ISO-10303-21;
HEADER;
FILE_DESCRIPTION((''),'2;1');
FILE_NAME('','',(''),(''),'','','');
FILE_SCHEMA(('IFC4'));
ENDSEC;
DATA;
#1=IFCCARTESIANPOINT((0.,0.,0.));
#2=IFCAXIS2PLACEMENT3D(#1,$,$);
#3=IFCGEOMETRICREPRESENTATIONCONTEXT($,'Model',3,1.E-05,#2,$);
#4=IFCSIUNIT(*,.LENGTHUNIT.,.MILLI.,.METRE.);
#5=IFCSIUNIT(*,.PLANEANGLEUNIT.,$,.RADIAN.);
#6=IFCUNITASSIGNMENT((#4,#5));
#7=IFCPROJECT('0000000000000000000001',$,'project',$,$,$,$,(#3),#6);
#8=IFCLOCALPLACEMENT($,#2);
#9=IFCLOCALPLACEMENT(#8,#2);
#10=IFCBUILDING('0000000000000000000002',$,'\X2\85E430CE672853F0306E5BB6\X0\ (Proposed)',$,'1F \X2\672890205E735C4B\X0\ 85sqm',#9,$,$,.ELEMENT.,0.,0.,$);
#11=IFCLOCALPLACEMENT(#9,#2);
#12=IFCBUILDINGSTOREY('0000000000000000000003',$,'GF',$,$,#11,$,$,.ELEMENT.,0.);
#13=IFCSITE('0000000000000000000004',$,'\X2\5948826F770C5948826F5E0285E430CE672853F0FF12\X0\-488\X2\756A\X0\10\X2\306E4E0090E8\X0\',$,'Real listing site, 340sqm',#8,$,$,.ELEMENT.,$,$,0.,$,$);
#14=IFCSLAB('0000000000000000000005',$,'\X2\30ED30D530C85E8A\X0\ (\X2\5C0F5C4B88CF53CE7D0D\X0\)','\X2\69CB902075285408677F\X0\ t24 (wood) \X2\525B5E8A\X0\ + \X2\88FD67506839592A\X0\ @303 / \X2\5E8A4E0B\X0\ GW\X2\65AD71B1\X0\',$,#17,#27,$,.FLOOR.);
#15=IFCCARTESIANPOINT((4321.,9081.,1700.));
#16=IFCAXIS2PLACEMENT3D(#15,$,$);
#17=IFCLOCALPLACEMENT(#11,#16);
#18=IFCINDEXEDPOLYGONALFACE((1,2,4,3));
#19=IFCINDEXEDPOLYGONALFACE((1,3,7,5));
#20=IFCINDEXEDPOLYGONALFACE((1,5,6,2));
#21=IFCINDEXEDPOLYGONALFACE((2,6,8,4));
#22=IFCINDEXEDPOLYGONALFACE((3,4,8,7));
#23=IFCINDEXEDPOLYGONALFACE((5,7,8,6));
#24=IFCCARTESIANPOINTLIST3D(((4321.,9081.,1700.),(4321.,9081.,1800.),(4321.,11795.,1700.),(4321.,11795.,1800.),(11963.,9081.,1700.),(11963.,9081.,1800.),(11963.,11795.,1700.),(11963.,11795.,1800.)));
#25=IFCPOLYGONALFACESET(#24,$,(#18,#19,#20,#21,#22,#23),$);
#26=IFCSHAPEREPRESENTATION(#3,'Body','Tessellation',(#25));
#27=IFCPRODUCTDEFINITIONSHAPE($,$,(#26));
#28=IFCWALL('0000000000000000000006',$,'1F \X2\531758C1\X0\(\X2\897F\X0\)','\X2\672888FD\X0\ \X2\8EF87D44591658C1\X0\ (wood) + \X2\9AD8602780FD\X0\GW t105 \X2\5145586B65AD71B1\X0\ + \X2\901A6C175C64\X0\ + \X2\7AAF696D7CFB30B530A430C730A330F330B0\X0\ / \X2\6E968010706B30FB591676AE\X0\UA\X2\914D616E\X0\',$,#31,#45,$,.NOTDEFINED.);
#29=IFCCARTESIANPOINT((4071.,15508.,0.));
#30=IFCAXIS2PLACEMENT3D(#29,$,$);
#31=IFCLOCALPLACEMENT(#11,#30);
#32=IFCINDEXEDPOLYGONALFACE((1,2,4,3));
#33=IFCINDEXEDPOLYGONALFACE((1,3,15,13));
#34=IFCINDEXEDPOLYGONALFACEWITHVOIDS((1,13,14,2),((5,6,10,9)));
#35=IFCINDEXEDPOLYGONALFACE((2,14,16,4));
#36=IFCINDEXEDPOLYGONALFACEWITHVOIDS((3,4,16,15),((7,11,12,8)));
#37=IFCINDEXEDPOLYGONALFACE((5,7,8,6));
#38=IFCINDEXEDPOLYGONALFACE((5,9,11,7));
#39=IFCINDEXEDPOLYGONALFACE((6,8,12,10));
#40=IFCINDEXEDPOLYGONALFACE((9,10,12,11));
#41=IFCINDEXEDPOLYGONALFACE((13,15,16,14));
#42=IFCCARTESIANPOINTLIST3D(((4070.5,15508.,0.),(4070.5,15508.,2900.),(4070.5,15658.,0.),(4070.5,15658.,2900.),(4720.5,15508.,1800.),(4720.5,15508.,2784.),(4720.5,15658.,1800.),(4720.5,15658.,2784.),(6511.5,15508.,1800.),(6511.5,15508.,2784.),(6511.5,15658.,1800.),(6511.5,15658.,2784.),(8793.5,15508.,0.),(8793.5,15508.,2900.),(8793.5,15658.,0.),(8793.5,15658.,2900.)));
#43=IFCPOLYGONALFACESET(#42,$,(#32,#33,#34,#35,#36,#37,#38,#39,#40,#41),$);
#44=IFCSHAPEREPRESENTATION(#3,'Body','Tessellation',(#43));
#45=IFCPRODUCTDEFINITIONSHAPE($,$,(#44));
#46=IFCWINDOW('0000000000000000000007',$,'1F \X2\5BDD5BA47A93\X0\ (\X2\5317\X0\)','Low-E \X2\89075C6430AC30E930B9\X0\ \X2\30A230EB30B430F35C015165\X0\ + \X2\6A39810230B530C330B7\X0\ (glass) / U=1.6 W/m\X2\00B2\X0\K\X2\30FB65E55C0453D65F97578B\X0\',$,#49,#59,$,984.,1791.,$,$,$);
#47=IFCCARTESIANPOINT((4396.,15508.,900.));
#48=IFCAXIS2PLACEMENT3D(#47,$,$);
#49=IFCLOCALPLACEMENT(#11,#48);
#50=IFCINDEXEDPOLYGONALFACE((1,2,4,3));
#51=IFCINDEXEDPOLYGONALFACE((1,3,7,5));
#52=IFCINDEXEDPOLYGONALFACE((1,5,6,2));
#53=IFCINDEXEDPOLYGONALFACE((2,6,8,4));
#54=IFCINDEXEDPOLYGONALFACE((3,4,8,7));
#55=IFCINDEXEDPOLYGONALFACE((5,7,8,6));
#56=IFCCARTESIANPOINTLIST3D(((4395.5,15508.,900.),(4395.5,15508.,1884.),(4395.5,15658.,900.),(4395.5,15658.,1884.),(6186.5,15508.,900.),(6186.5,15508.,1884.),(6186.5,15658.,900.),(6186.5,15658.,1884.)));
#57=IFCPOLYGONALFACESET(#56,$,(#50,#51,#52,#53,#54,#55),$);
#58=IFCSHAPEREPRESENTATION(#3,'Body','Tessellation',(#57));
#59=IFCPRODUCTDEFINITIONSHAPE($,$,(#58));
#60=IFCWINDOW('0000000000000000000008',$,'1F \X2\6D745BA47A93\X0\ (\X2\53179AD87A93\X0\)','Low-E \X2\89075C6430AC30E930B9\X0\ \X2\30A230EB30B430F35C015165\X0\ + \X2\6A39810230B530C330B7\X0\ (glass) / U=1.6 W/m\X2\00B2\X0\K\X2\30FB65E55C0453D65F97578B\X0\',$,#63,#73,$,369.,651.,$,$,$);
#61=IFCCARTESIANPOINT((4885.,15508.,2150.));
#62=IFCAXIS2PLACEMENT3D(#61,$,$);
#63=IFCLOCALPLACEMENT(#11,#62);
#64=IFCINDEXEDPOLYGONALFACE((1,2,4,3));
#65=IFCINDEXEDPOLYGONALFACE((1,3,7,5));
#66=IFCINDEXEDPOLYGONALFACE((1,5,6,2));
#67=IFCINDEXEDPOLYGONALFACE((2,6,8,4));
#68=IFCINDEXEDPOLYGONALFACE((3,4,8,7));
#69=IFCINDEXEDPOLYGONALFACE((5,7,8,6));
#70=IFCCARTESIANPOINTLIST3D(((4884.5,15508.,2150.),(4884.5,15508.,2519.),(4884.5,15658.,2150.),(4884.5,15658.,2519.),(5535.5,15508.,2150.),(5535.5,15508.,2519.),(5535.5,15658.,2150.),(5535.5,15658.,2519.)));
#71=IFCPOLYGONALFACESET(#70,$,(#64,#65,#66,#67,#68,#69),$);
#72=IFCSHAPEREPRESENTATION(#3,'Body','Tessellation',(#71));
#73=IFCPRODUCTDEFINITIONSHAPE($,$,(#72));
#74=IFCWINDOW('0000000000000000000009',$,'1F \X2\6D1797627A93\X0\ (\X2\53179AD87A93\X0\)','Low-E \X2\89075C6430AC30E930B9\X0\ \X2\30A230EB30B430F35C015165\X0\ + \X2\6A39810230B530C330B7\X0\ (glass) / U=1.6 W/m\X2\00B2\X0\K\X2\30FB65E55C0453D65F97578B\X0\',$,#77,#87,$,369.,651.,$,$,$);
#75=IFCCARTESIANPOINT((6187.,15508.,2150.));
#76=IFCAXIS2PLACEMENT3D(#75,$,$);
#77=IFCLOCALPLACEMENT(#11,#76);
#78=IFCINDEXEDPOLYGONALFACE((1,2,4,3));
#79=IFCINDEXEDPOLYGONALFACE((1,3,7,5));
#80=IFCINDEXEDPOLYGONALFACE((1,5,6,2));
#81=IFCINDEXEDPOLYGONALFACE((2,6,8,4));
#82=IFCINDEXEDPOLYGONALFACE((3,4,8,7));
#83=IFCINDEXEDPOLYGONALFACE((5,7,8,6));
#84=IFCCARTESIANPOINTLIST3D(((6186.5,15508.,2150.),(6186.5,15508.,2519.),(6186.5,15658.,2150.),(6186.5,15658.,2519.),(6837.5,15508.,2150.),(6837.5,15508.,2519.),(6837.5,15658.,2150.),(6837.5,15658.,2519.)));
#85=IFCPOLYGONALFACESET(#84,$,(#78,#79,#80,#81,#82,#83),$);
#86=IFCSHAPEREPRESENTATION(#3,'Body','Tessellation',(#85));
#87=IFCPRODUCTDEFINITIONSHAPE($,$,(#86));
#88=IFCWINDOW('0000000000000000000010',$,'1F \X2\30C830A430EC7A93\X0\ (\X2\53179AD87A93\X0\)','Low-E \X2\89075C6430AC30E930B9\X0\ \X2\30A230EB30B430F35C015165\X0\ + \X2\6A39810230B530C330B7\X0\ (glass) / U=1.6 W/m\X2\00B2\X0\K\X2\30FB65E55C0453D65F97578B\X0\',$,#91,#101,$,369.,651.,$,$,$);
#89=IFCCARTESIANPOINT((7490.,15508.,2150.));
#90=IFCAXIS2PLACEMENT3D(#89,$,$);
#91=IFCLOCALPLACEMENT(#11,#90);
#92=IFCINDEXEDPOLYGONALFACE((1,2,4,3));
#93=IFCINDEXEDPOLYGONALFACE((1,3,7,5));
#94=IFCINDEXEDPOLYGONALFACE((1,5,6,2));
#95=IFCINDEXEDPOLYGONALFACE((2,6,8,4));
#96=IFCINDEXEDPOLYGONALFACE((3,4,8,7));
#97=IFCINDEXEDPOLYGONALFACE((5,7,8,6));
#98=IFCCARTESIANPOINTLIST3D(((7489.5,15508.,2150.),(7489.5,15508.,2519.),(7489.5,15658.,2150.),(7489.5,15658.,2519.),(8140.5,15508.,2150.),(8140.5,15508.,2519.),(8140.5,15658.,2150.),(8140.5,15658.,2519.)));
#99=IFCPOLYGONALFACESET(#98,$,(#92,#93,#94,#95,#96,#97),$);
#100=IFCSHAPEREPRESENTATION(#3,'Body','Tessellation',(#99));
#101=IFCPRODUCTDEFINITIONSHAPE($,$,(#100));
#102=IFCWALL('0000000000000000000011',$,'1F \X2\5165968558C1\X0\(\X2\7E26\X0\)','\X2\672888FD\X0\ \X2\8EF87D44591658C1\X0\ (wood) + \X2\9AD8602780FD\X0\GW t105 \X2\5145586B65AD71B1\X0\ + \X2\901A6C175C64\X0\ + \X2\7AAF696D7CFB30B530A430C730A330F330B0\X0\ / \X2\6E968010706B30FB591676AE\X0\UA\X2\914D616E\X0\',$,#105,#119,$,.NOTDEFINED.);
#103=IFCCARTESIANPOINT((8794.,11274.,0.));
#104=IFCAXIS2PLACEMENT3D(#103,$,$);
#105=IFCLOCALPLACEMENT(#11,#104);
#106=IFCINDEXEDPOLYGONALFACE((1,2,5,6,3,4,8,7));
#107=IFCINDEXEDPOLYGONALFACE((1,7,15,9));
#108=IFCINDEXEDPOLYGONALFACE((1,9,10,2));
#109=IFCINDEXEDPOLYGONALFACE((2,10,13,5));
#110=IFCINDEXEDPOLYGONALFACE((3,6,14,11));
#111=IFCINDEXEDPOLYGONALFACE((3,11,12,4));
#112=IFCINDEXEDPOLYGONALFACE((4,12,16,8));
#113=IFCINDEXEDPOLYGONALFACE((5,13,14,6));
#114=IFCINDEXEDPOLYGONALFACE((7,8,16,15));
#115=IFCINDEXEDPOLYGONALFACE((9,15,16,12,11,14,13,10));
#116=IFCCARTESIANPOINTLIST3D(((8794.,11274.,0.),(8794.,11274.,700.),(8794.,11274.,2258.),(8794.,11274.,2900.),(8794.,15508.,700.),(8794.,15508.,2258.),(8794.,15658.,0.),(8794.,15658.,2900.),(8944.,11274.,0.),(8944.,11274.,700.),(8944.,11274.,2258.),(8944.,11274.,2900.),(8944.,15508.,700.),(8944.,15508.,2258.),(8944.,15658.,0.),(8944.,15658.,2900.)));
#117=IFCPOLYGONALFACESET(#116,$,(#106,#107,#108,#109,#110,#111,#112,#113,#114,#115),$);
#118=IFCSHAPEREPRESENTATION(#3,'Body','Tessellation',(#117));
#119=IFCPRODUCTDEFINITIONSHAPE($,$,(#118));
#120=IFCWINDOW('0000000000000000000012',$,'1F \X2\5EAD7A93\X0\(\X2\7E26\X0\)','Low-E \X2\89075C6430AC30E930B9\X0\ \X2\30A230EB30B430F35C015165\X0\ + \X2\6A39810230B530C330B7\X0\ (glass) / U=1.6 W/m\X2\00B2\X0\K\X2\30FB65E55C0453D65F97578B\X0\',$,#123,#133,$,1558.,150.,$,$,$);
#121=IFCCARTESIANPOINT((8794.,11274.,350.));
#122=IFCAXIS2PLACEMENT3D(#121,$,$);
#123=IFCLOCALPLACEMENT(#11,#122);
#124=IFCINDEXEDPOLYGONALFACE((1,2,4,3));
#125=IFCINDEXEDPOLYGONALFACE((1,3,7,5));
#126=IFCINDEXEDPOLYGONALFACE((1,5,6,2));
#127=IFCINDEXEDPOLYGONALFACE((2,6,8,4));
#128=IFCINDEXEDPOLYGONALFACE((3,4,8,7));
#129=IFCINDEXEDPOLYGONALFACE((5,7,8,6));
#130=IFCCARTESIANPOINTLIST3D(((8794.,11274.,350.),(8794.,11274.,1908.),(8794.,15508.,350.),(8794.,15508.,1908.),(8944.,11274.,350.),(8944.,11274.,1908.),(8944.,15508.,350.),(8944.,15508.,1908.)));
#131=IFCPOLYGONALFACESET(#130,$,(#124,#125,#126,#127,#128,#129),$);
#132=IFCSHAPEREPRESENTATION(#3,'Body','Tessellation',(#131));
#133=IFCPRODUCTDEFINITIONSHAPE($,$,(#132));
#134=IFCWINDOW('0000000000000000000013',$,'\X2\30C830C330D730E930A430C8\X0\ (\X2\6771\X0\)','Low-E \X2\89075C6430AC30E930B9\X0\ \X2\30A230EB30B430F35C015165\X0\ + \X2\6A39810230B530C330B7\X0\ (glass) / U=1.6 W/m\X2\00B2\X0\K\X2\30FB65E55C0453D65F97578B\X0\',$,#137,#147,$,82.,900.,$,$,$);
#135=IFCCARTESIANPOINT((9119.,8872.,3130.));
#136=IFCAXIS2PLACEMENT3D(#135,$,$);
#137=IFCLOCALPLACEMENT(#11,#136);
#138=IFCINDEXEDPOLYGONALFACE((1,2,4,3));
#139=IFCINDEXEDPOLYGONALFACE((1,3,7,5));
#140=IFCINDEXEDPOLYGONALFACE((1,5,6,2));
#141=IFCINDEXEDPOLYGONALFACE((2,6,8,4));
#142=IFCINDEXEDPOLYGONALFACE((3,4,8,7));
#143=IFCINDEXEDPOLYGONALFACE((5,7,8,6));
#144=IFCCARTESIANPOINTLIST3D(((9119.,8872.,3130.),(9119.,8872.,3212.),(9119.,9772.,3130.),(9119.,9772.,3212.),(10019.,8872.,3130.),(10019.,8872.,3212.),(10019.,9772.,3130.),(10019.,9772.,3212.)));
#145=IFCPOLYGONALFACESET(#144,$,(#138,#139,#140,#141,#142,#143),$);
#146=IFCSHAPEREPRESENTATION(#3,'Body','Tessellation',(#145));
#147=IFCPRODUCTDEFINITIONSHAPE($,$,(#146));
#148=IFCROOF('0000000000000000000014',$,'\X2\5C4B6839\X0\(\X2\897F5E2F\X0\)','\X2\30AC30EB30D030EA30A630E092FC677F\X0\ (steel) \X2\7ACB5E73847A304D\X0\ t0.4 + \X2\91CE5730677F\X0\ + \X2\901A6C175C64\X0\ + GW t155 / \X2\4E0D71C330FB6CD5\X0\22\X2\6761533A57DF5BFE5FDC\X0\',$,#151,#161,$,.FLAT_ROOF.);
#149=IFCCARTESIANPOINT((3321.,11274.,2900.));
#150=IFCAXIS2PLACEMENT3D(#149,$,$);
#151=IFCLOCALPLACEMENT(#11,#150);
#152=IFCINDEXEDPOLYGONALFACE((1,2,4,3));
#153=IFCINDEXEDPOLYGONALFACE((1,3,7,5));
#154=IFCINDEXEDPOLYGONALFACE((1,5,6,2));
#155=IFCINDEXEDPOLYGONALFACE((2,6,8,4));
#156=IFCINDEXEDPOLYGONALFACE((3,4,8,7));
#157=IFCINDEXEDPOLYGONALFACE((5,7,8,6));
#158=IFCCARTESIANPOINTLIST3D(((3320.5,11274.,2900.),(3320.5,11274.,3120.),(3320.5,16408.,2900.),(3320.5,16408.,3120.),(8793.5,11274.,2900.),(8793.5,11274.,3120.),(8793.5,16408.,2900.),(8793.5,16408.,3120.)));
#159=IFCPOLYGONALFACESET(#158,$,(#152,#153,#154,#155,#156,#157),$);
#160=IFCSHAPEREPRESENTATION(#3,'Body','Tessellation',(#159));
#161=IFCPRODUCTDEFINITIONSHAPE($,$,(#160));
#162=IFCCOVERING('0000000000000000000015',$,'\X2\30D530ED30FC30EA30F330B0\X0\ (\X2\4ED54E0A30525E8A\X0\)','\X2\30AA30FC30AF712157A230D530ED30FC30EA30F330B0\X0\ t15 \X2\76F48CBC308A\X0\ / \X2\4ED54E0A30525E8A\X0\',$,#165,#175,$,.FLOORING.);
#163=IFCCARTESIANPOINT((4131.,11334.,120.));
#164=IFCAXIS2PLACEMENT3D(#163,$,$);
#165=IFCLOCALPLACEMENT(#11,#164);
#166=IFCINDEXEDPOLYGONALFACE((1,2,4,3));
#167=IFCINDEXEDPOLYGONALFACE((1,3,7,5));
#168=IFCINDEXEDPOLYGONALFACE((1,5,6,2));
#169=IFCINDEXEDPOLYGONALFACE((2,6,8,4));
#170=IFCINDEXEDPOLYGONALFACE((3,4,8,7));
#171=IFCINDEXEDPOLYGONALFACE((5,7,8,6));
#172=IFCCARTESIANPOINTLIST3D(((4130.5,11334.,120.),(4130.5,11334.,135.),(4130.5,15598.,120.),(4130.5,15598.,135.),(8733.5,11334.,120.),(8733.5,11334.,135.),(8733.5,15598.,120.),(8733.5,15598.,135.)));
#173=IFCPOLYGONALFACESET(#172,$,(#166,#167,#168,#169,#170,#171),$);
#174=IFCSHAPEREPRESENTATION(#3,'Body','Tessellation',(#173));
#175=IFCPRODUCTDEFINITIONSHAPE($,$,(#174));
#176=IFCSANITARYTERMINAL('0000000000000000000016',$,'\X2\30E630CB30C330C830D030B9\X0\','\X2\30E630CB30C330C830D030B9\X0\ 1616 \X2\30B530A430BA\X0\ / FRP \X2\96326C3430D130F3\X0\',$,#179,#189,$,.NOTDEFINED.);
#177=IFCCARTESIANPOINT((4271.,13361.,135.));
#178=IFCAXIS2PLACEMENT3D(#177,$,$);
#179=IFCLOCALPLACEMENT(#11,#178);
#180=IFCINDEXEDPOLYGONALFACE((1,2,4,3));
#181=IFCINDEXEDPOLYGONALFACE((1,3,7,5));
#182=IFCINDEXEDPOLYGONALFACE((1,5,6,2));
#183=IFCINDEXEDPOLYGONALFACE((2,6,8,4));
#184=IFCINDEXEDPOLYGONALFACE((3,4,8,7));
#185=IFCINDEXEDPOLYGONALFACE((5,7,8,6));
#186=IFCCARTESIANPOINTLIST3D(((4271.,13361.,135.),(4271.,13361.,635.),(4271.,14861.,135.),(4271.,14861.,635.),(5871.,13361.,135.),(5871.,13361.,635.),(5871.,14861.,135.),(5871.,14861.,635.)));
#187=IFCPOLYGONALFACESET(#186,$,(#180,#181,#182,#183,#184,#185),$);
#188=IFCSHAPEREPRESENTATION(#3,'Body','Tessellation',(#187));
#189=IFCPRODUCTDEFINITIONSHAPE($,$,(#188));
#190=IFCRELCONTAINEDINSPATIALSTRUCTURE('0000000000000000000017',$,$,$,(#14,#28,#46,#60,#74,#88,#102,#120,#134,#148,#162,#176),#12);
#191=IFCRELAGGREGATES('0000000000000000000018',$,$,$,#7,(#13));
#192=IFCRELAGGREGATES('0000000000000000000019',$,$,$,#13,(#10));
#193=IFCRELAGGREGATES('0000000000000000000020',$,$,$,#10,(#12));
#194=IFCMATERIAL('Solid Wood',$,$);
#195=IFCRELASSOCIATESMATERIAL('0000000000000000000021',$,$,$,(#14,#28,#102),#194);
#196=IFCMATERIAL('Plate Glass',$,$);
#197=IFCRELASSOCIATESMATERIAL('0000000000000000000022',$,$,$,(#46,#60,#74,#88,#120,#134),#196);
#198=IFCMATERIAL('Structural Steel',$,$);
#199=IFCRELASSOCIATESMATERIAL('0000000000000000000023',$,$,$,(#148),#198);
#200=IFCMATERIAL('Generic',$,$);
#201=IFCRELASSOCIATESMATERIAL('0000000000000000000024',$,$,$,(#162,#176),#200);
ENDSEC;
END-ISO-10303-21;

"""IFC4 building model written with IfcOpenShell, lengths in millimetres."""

from ifc_helpers import new_model, si_unit, frame, frame_2d, origin, place, context, project, spatial, rectangle, extrude, material, element, fill, save


model = new_model("IFC4")

# Units and contexts
model_context = context("Model", 3, precision=1e-05, world=origin())
ifc_project = project(units=[si_unit("LENGTHUNIT", "METRE", prefix="MILLI"), si_unit("PLANEANGLEUNIT", "RADIAN")], contexts=[model_context])

# Site, building, storey
site_placement = place(None, origin())
site = spatial("IfcSite", under=ifc_project, at=site_placement, Name="奈良県奈良市藤ノ木台２-488番10の一部", ObjectType="Real listing site, 340sqm", CompositionType="ELEMENT", RefElevation=0.0)
building_placement = place(site_placement, origin())
building = spatial("IfcBuilding", under=site, at=building_placement, Name="藤ノ木台の家 (Proposed)", ObjectType="1F 木造平屋 85sqm", CompositionType="ELEMENT", ElevationOfRefHeight=0.0, ElevationOfTerrain=0.0)
storey_placement = place(building_placement, origin())
storey = spatial("IfcBuildingStorey", under=building, at=storey_placement, Name="GF", CompositionType="ELEMENT", Elevation=0.0)

# Slab
ifc_material_1 = material(Name="Solid Wood")
slab_1_placement = place(storey_placement, frame((4321.0, 9081.0, 1700.0)))
element("IfcSlab", 1, at=slab_1_placement, inside=storey, material=ifc_material_1, Name="ロフト床 (小屋裏収納)", Description="構造用合板 t24 (wood) 剛床 + 製材根太 @303 / 床下 GW断熱", PredefinedType="FLOOR", context=model_context, shape_type="SweptSolid", body=[
    extrude(rectangle(XDim=7642.0, YDim=2714.0, at=frame_2d((3821.0, 1357.0))), frame((4321.0, 9081.0, 1700.0)), (0.0, 0.0, 1.0), 100.0),
])

# Wall, openings, windows
wall_1_placement = place(storey_placement, frame((4071.0, 15508.0, 0.0)))
wall_1 = element("IfcWall", 2, at=wall_1_placement, inside=storey, material=ifc_material_1, Name="1F 北壁(西)", Description="木製 軸組外壁 (wood) + 高性能GW t105 充填断熱 + 通気層 + 窯業系サイディング / 準耐火・外皮UA配慮", PredefinedType="NOTDEFINED", context=model_context, shape_type="SweptSolid", body=[
    extrude(rectangle(XDim=4723.0, YDim=150.0, at=frame_2d((2361.0, 75.0))), frame((4071.0, 15508.0, 0.0)), (0.0, 0.0, 1.0), 2900.0),
])
opening_1_placement = place(storey_placement, frame((4396.0, 15508.0, 900.0)))
opening_1 = element("IfcOpeningElement", 3, at=opening_1_placement, cuts=wall_1, PredefinedType="NOTDEFINED", context=model_context, shape_type="SweptSolid", body=[
    extrude(rectangle(XDim=1791.0, YDim=150.0, at=frame_2d((895.0, 75.0))), frame((4396.0, 15508.0, 900.0)), (0.0, 0.0, 1.0), 984.0),
])
opening_2_placement = place(storey_placement, frame((4885.0, 15508.0, 2150.0)))
opening_2 = element("IfcOpeningElement", 4, at=opening_2_placement, cuts=wall_1, PredefinedType="NOTDEFINED", context=model_context, shape_type="SweptSolid", body=[
    extrude(rectangle(XDim=651.0, YDim=150.0, at=frame_2d((325.0, 75.0))), frame((4885.0, 15508.0, 2150.0)), (0.0, 0.0, 1.0), 369.0),
])
opening_3_placement = place(storey_placement, frame((6187.0, 15508.0, 2150.0)))
opening_3 = element("IfcOpeningElement", 5, at=opening_3_placement, cuts=wall_1, PredefinedType="NOTDEFINED", context=model_context, shape_type="SweptSolid", body=[
    extrude(rectangle(XDim=651.0, YDim=150.0, at=frame_2d((325.0, 75.0))), frame((6187.0, 15508.0, 2150.0)), (0.0, 0.0, 1.0), 369.0),
])
opening_4_placement = place(storey_placement, frame((7490.0, 15508.0, 2150.0)))
opening_4 = element("IfcOpeningElement", 6, at=opening_4_placement, cuts=wall_1, PredefinedType="NOTDEFINED", context=model_context, shape_type="SweptSolid", body=[
    extrude(rectangle(XDim=651.0, YDim=150.0, at=frame_2d((325.0, 75.0))), frame((7490.0, 15508.0, 2150.0)), (0.0, 0.0, 1.0), 369.0),
])
ifc_material_2 = material(Name="Plate Glass")
window_1_placement = place(storey_placement, frame((4396.0, 15508.0, 900.0)))
window_1 = element("IfcWindow", 7, at=window_1_placement, inside=storey, material=ifc_material_2, Name="1F 寝室窓 (北)", Description="Low-E 複層ガラス アルゴン封入 + 樹脂サッシ (glass) / U=1.6 W/m²K・日射取得型", OverallHeight=984.0, OverallWidth=1791.0, context=model_context, shape_type="SweptSolid", body=[
    extrude(rectangle(XDim=1791.0, YDim=150.0, at=frame_2d((895.0, 75.0))), frame((4396.0, 15508.0, 900.0)), (0.0, 0.0, 1.0), 984.0),
])
fill(opening_1, window_1)
window_2_placement = place(storey_placement, frame((4885.0, 15508.0, 2150.0)))
window_2 = element("IfcWindow", 8, at=window_2_placement, inside=storey, material=ifc_material_2, Name="1F 浴室窓 (北高窓)", Description="Low-E 複層ガラス アルゴン封入 + 樹脂サッシ (glass) / U=1.6 W/m²K・日射取得型", OverallHeight=369.0, OverallWidth=651.0, context=model_context, shape_type="SweptSolid", body=[
    extrude(rectangle(XDim=651.0, YDim=150.0, at=frame_2d((325.0, 75.0))), frame((4885.0, 15508.0, 2150.0)), (0.0, 0.0, 1.0), 369.0),
])
fill(opening_2, window_2)
window_3_placement = place(storey_placement, frame((6187.0, 15508.0, 2150.0)))
window_3 = element("IfcWindow", 9, at=window_3_placement, inside=storey, material=ifc_material_2, Name="1F 洗面窓 (北高窓)", Description="Low-E 複層ガラス アルゴン封入 + 樹脂サッシ (glass) / U=1.6 W/m²K・日射取得型", OverallHeight=369.0, OverallWidth=651.0, context=model_context, shape_type="SweptSolid", body=[
    extrude(rectangle(XDim=651.0, YDim=150.0, at=frame_2d((325.0, 75.0))), frame((6187.0, 15508.0, 2150.0)), (0.0, 0.0, 1.0), 369.0),
])
fill(opening_3, window_3)
window_4_placement = place(storey_placement, frame((7490.0, 15508.0, 2150.0)))
window_4 = element("IfcWindow", 10, at=window_4_placement, inside=storey, material=ifc_material_2, Name="1F トイレ窓 (北高窓)", Description="Low-E 複層ガラス アルゴン封入 + 樹脂サッシ (glass) / U=1.6 W/m²K・日射取得型", OverallHeight=369.0, OverallWidth=651.0, context=model_context, shape_type="SweptSolid", body=[
    extrude(rectangle(XDim=651.0, YDim=150.0, at=frame_2d((325.0, 75.0))), frame((7490.0, 15508.0, 2150.0)), (0.0, 0.0, 1.0), 369.0),
])
fill(opening_4, window_4)

# Wall, opening, window
wall_2_placement = place(storey_placement, frame((8794.0, 11274.0, 0.0)))
wall_2 = element("IfcWall", 11, at=wall_2_placement, inside=storey, material=ifc_material_1, Name="1F 入隅壁(縦)", Description="木製 軸組外壁 (wood) + 高性能GW t105 充填断熱 + 通気層 + 窯業系サイディング / 準耐火・外皮UA配慮", PredefinedType="NOTDEFINED", context=model_context, shape_type="SweptSolid", body=[
    extrude(rectangle(XDim=150.0, YDim=4384.0, at=frame_2d((75.0, 2192.0))), frame((8794.0, 11274.0, 0.0)), (0.0, 0.0, 1.0), 2900.0),
])
opening_5_placement = place(storey_placement, frame((8794.0, 11274.0, 350.0)))
opening_5 = element("IfcOpeningElement", 12, at=opening_5_placement, cuts=wall_2, PredefinedType="NOTDEFINED", context=model_context, shape_type="SweptSolid", body=[
    extrude(rectangle(XDim=150.0, YDim=4234.0, at=frame_2d((75.0, 2117.0))), frame((8794.0, 11274.0, 350.0)), (0.0, 0.0, 1.0), 1558.0),
])
window_5_placement = place(storey_placement, frame((8794.0, 11274.0, 350.0)))
window_5 = element("IfcWindow", 13, at=window_5_placement, inside=storey, material=ifc_material_2, Name="1F 庭窓(縦)", Description="Low-E 複層ガラス アルゴン封入 + 樹脂サッシ (glass) / U=1.6 W/m²K・日射取得型", OverallHeight=1558.0, OverallWidth=150.0, context=model_context, shape_type="SweptSolid", body=[
    extrude(rectangle(XDim=150.0, YDim=4234.0, at=frame_2d((75.0, 2117.0))), frame((8794.0, 11274.0, 350.0)), (0.0, 0.0, 1.0), 1558.0),
])
fill(opening_5, window_5)

# Window
window_6_placement = place(storey_placement, frame((9119.0, 8872.0, 3130.0)))
element("IfcWindow", 14, at=window_6_placement, inside=storey, material=ifc_material_2, Name="トップライト (東)", Description="Low-E 複層ガラス アルゴン封入 + 樹脂サッシ (glass) / U=1.6 W/m²K・日射取得型", OverallHeight=82.0, OverallWidth=900.0, context=model_context, shape_type="SweptSolid", body=[
    extrude(rectangle(XDim=900.0, YDim=900.0, at=frame_2d((450.0, 450.0))), frame((9119.0, 8872.0, 3130.0)), (0.0, 0.0, 1.0), 82.0),
])

# Roof
ifc_material_3 = material(Name="Structural Steel")
roof_placement = place(storey_placement, frame((3321.0, 11274.0, 2900.0)))
element("IfcRoof", 15, at=roof_placement, inside=storey, material=ifc_material_3, Name="屋根(西帯)", Description="ガルバリウム鋼板 (steel) 立平葺き t0.4 + 野地板 + 通気層 + GW t155 / 不燃・法22条区域対応", PredefinedType="FLAT_ROOF", context=model_context, shape_type="SweptSolid", body=[
    extrude(rectangle(XDim=5473.0, YDim=5134.0, at=frame_2d((2736.0, 2567.0))), frame((3321.0, 11274.0, 2900.0)), (0.0, 0.0, 1.0), 220.0),
])

# Covering
ifc_material_4 = material(Name="Generic")
covering_placement = place(storey_placement, frame((4131.0, 11334.0, 120.0)))
element("IfcCovering", 16, at=covering_placement, inside=storey, material=ifc_material_4, Name="フローリング (仕上げ床)", Description="オーク無垢フローリング t15 直貼り / 仕上げ床", PredefinedType="FLOORING", context=model_context, shape_type="SweptSolid", body=[
    extrude(rectangle(XDim=4603.0, YDim=4264.0, at=frame_2d((2301.0, 2132.0))), frame((4131.0, 11334.0, 120.0)), (0.0, 0.0, 1.0), 15.0),
])

# Sanitary terminal
sanitary_terminal_1_placement = place(storey_placement, frame((4271.0, 13361.0, 135.0)))
element("IfcSanitaryTerminal", 17, at=sanitary_terminal_1_placement, inside=storey, material=ifc_material_4, Name="ユニットバス", Description="ユニットバス 1616 サイズ / FRP 防水パン", PredefinedType="NOTDEFINED", context=model_context, shape_type="SweptSolid", body=[
    extrude(rectangle(XDim=1600.0, YDim=1500.0, at=frame_2d((800.0, 750.0))), frame((4271.0, 13361.0, 135.0)), (0.0, 0.0, 1.0), 500.0),
])

save(model, "model.ifc")
